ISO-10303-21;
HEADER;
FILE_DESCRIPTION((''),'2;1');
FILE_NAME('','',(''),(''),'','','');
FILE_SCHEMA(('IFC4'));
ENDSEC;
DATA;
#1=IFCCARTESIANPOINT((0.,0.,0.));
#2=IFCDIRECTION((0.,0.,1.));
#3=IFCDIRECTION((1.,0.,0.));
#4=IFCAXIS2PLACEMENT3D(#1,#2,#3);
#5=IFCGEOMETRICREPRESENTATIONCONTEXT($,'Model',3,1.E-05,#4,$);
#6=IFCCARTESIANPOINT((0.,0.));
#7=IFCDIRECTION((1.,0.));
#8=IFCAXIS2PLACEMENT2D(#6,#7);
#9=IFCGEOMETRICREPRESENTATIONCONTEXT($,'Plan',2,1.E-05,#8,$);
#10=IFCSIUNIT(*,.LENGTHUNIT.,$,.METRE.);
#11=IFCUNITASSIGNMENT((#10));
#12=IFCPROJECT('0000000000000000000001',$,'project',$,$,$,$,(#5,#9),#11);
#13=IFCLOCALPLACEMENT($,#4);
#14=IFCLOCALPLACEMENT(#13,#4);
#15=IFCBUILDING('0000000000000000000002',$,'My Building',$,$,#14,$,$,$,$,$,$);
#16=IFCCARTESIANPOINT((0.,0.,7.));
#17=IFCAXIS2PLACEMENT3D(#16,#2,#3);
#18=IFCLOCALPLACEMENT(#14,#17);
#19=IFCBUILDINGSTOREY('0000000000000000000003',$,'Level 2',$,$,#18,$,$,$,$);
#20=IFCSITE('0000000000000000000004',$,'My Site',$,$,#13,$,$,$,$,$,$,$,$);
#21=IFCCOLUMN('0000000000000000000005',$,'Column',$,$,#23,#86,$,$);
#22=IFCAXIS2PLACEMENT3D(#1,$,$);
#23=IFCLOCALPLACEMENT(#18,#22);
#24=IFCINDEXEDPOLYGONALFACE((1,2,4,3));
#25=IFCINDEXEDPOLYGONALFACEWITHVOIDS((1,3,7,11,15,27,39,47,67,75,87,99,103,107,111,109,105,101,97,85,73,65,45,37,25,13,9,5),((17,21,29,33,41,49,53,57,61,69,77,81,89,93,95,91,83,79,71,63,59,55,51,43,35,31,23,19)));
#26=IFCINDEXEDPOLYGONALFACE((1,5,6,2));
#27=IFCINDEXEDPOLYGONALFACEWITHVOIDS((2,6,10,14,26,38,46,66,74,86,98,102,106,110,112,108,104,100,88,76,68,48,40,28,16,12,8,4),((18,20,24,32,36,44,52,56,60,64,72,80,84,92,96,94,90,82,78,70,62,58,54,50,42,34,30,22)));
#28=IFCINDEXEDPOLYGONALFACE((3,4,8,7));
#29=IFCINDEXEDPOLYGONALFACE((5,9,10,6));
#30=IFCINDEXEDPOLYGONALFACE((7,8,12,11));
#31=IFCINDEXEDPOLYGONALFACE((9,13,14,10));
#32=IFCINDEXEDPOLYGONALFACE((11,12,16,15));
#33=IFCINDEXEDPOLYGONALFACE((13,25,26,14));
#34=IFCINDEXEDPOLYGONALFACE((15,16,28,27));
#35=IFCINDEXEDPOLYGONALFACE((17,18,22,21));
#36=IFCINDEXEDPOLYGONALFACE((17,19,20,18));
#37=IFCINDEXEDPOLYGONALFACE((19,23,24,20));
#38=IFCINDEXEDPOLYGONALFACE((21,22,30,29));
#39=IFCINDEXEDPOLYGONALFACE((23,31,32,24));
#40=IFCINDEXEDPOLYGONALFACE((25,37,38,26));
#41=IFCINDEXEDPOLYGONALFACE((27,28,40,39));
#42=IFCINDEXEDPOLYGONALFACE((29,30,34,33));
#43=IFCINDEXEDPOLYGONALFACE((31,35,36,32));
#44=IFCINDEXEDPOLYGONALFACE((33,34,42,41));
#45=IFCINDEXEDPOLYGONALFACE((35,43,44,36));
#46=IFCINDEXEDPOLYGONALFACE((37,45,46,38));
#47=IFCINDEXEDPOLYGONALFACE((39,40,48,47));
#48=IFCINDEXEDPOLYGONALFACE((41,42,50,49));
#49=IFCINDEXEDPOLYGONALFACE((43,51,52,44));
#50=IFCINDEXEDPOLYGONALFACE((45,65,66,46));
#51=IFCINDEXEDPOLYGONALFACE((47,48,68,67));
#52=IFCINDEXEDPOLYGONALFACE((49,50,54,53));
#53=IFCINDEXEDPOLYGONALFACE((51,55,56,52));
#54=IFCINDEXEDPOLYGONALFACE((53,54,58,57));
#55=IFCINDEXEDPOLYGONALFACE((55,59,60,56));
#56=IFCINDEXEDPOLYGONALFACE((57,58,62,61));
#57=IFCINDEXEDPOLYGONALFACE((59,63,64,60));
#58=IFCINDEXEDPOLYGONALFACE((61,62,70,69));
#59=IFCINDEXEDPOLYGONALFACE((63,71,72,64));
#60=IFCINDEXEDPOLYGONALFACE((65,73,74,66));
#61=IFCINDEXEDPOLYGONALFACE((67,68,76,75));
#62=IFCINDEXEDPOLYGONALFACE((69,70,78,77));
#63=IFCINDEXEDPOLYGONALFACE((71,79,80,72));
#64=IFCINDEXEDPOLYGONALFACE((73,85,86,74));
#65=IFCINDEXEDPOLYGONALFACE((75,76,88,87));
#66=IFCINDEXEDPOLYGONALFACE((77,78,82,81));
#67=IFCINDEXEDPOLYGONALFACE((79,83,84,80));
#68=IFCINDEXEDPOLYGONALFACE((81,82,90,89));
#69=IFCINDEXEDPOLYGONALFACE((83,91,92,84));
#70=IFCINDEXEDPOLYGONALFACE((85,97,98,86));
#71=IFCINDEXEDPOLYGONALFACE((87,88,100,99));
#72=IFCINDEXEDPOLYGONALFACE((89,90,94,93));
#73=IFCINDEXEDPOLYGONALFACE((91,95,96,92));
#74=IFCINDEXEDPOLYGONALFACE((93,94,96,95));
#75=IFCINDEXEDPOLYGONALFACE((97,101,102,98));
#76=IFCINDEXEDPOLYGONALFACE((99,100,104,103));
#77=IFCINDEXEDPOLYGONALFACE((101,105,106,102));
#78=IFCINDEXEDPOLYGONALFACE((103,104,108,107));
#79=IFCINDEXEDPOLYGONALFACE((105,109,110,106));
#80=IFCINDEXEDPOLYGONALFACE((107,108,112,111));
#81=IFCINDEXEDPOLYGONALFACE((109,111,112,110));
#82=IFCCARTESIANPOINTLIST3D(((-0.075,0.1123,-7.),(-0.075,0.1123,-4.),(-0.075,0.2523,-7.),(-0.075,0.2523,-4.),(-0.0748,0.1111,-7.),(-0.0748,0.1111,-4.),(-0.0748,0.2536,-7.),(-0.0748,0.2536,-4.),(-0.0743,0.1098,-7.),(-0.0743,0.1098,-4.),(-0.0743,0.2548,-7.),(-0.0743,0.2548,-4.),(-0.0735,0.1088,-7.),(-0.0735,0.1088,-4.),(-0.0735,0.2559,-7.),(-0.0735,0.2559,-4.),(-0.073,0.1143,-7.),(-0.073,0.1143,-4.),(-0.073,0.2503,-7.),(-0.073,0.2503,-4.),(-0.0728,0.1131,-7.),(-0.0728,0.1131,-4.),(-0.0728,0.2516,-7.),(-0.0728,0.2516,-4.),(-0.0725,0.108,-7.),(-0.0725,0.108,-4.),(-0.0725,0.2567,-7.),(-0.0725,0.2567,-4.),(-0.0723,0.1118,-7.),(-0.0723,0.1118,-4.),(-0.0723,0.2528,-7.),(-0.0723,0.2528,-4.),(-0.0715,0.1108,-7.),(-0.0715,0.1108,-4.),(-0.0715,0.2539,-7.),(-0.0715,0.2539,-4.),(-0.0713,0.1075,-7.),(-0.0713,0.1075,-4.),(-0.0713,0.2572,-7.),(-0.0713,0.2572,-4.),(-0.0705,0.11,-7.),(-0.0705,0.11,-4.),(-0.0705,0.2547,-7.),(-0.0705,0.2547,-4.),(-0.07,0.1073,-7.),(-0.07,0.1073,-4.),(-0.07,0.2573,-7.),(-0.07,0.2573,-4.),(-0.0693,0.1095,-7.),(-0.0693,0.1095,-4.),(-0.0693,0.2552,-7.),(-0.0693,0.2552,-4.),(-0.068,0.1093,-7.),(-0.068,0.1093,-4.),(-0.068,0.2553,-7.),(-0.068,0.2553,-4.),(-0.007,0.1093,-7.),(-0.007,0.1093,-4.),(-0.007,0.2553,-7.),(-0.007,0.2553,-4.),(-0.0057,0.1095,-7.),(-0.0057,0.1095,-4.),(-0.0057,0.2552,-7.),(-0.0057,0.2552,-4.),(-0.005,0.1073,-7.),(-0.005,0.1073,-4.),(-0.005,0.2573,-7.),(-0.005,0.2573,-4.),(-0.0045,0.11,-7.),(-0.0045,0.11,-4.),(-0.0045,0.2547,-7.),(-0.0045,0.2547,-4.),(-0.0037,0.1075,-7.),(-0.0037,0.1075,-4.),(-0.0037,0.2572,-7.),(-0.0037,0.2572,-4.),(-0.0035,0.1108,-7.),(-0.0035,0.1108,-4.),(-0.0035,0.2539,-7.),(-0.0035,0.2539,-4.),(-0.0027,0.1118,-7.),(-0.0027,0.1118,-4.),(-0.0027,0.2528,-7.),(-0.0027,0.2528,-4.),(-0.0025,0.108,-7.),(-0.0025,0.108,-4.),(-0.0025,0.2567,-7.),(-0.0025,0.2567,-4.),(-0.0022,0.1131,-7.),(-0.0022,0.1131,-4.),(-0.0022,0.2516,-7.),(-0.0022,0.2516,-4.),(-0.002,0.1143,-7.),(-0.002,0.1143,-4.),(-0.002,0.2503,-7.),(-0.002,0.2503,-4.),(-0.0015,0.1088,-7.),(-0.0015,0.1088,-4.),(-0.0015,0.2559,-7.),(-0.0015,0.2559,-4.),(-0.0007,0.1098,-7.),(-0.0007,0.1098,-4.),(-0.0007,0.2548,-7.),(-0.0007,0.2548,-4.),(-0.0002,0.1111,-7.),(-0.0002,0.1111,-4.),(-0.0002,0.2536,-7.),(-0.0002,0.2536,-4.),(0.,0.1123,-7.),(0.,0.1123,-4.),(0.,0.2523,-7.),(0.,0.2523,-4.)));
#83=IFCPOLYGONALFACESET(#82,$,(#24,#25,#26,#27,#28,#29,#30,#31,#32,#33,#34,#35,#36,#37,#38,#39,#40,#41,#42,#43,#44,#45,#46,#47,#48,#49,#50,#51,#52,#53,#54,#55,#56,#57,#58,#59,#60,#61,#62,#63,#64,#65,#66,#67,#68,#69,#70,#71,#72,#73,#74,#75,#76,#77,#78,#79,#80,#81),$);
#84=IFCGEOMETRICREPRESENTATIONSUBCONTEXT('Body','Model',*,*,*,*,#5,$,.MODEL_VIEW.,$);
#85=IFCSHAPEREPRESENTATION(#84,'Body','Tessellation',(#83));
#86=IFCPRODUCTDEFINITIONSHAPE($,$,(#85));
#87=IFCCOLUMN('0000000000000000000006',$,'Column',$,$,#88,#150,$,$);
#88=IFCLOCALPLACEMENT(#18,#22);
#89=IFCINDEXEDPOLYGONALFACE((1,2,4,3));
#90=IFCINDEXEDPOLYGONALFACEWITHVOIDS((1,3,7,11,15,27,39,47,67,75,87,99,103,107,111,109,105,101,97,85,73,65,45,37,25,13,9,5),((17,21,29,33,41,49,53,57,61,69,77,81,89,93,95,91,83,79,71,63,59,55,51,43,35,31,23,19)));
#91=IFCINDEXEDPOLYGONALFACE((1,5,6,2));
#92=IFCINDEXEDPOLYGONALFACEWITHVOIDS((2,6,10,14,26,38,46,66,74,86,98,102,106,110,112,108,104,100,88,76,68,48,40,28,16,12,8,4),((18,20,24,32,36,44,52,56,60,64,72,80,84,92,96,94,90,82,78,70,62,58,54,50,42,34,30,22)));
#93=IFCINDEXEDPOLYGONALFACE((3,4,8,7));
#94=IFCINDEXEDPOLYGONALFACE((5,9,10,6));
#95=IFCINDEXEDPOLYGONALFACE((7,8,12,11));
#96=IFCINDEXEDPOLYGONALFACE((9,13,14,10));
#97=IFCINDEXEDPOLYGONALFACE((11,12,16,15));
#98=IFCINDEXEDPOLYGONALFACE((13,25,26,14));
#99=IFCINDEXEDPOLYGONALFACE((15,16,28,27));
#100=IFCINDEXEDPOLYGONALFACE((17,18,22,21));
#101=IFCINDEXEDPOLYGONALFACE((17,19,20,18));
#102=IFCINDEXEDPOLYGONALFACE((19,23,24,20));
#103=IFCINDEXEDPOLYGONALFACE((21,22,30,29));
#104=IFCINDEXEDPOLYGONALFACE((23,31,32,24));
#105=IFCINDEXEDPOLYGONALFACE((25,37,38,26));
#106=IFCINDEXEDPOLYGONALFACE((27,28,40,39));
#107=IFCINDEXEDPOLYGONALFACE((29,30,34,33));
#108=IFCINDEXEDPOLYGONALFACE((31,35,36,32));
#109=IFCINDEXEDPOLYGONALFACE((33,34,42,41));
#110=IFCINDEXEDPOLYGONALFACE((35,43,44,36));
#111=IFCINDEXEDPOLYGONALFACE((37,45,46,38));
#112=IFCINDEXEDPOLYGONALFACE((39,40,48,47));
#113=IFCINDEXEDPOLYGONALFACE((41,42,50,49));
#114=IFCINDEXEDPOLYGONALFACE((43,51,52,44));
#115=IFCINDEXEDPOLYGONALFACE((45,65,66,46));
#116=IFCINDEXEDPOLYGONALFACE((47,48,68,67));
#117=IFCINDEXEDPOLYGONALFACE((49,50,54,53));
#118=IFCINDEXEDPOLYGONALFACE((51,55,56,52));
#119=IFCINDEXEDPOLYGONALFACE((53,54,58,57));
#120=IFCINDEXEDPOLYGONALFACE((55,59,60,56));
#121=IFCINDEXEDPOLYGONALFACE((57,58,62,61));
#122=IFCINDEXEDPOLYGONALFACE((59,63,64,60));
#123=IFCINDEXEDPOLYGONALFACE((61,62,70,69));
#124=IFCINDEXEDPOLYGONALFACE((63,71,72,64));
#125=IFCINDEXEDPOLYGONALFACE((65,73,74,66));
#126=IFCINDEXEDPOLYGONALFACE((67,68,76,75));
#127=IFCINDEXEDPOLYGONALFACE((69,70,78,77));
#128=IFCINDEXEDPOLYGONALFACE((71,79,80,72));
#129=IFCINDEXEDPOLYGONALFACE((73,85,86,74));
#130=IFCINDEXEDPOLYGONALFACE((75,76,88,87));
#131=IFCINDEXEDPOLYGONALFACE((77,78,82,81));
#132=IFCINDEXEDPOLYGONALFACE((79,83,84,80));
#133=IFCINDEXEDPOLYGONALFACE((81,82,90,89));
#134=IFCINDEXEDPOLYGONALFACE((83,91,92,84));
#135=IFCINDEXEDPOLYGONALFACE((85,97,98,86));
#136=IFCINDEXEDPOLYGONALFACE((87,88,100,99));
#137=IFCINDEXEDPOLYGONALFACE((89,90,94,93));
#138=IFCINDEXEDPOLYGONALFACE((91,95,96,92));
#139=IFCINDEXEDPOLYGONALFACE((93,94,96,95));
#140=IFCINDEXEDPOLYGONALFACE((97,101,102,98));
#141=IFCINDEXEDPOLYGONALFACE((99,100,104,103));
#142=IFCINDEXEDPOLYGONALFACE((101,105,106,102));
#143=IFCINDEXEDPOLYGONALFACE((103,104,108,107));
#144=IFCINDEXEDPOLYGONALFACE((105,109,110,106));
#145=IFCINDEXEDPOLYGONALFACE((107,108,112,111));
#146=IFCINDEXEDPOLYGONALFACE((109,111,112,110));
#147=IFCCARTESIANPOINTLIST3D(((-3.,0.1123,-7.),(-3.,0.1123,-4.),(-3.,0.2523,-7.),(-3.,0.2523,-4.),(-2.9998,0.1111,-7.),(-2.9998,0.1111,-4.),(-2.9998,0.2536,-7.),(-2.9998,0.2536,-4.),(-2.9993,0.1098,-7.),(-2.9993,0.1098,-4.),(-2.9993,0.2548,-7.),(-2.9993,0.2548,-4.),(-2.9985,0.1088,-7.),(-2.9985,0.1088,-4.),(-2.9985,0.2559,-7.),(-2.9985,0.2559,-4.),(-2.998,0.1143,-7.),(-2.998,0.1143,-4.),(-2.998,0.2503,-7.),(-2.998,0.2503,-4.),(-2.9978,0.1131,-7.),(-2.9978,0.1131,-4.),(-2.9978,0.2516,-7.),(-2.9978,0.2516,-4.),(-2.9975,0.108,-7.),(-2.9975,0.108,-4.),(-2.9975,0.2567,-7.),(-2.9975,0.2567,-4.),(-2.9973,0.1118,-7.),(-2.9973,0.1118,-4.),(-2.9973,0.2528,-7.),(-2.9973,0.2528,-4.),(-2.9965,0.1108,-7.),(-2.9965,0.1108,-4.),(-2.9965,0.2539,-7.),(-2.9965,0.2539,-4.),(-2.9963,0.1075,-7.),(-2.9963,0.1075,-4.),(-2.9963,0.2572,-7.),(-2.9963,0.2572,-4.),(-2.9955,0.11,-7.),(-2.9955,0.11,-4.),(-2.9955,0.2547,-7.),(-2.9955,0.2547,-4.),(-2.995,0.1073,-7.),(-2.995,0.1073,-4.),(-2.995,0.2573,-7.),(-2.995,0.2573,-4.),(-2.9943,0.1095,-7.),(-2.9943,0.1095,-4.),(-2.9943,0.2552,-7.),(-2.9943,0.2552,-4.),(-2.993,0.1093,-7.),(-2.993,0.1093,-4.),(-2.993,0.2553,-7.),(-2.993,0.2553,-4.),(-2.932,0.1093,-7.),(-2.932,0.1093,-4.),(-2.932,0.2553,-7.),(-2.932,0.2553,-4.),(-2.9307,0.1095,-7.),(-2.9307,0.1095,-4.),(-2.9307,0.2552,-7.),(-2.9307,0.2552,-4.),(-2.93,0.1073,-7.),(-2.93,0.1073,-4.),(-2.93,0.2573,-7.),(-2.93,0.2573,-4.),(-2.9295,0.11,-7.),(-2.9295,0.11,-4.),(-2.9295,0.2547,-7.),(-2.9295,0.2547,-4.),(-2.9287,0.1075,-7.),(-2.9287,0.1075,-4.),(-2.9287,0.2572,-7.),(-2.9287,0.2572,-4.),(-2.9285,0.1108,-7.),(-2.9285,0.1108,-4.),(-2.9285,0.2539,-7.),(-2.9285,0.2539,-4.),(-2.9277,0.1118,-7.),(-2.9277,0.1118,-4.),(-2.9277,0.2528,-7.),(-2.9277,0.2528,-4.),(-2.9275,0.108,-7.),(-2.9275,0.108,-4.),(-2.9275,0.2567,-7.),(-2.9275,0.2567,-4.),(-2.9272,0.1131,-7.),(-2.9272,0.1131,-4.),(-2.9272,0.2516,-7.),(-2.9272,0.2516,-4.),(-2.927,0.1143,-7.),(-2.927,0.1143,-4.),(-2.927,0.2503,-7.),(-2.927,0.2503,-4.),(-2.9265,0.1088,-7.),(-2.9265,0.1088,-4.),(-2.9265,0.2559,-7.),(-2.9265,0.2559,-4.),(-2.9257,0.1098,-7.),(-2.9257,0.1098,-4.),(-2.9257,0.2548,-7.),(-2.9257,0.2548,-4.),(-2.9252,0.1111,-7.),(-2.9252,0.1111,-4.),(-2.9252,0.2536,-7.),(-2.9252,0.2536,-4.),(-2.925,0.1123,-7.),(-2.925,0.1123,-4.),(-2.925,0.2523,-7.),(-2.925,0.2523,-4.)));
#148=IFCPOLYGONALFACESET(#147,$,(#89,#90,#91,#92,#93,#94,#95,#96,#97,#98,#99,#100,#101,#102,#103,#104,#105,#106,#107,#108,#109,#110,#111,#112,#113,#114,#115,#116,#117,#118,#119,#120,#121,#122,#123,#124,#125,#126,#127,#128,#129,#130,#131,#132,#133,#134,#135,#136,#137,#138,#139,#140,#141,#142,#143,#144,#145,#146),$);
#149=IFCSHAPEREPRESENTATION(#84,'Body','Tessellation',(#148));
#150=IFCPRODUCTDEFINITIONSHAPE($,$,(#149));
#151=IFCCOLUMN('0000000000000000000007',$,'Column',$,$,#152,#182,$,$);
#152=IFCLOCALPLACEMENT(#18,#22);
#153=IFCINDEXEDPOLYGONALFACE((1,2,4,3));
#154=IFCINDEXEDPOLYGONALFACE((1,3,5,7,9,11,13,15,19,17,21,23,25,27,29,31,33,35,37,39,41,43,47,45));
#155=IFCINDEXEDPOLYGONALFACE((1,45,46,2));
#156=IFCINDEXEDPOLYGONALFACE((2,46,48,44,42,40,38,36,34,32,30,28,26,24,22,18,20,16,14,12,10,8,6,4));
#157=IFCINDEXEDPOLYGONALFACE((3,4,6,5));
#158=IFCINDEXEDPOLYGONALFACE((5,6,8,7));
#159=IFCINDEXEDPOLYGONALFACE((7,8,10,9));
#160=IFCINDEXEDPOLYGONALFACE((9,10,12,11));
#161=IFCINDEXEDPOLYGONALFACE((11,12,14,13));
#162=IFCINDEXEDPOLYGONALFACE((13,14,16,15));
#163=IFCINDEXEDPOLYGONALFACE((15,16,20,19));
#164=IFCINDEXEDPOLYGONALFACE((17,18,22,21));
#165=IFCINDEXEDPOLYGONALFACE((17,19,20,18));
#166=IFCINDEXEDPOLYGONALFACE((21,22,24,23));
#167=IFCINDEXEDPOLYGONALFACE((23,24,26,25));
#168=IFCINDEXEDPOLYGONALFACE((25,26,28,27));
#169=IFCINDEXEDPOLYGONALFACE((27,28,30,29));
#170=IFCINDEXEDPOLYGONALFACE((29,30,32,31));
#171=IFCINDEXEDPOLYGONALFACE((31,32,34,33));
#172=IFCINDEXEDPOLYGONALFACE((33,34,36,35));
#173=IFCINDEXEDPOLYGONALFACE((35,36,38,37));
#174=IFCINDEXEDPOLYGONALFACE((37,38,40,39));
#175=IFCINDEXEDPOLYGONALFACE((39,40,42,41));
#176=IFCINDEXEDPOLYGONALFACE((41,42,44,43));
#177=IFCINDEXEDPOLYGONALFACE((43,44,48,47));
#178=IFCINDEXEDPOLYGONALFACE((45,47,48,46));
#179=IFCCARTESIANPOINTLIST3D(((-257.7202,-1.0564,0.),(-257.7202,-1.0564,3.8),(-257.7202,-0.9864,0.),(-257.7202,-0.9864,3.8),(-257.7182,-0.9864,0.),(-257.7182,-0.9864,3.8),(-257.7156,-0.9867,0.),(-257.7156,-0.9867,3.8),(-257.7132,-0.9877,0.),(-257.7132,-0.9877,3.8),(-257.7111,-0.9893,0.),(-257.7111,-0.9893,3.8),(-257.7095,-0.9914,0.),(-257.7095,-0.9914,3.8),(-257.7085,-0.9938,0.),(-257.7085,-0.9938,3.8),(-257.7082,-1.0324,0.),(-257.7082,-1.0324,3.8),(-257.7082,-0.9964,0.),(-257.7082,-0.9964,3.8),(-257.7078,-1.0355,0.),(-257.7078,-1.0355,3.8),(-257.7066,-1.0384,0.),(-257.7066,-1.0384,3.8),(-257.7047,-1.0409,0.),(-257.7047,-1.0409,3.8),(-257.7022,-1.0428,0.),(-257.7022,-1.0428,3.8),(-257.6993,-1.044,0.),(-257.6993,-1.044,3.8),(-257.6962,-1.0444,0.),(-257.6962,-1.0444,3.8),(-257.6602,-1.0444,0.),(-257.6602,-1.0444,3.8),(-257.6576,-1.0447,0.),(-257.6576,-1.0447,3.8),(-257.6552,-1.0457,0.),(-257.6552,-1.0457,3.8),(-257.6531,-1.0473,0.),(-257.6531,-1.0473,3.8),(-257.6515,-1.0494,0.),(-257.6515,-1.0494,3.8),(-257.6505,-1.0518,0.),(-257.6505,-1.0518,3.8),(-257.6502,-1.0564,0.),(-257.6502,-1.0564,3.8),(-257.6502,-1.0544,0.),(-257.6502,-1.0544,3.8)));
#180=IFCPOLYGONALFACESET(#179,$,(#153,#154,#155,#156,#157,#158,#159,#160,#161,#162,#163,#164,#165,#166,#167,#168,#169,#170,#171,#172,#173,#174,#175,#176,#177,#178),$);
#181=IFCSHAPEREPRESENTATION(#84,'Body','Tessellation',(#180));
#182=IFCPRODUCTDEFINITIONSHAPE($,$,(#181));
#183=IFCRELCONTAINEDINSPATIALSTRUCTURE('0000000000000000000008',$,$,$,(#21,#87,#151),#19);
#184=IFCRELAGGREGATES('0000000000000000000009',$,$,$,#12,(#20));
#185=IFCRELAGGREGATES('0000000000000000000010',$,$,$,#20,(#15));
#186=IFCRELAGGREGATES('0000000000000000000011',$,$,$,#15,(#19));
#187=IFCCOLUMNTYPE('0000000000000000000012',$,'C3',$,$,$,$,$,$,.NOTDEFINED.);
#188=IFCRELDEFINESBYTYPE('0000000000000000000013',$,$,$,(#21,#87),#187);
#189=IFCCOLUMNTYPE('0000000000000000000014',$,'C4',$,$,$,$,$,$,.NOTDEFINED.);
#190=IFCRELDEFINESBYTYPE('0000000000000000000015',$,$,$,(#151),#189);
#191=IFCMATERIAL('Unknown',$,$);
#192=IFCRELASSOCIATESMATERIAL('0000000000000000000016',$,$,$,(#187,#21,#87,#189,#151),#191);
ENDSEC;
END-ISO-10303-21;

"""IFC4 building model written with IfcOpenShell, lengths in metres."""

from ifc_helpers import new_model, si_unit, frame, origin_with_axes, origin_2d_with_axis, place, context, subcontext, project, spatial, hollow_rectangle, l_section, extrude, material, material_profile, profile_set, profile_usage, type_object, element, save


model = new_model("IFC4")

# Units and contexts
model_context = context("Model", 3, precision=1e-05, world=origin_with_axes())
plan_context = context("Plan", 2, precision=1e-05, world=origin_2d_with_axis())
body_context = subcontext(model_context, "Body", "Model", "MODEL_VIEW")
ifc_project = project(units=[si_unit("LENGTHUNIT", "METRE")], contexts=[model_context, plan_context])

# Site, building, storey
site_placement = place(None, origin_with_axes())
site = spatial("IfcSite", under=ifc_project, at=site_placement, Name="My Site")
building_placement = place(site_placement, origin_with_axes())
building = spatial("IfcBuilding", under=site, at=building_placement, Name="My Building")
storey_placement = place(building_placement, frame((0.0, 0.0, 7.0), z_axis=(0.0, 0.0, 1.0), x_axis=(1.0, 0.0, 0.0)))
storey = spatial("IfcBuildingStorey", under=building, at=storey_placement, Name="Level 2")

# Columns
ifc_material = material(Name="Unknown")
ifc_material_profile_1 = material_profile(ifc_material, hollow_rectangle(XDim=0.075, YDim=0.15, WallThickness=0.002, InnerFilletRadius=0.005, OuterFilletRadius=0.005))
ifc_profile_set_1 = profile_set([ifc_material_profile_1])
ifc_profile_usage_1 = profile_usage(ifc_profile_set_1, cardinal=5)
column_type_1 = type_object("IfcColumnType", Name="C3", PredefinedType="NOTDEFINED", material=ifc_profile_set_1)
column_1_placement = place(storey_placement, frame((-0.0375, 0.1823, -7.0), z_axis=(0.0, 0.0, 1.0), x_axis=(1.0, 0.0, 0.0)))
element("IfcColumn", 1, at=column_1_placement, inside=storey, type_object=column_type_1, material=ifc_profile_usage_1, Name="Column", context=body_context, shape_type="SweptSolid", body=[
    extrude(hollow_rectangle(XDim=0.075, YDim=0.15, WallThickness=0.002, InnerFilletRadius=0.005, OuterFilletRadius=0.005), origin_with_axes(), (0.0, 0.0, 1.0), 3.0),
])
ifc_profile_usage_2 = profile_usage(ifc_profile_set_1, cardinal=5)
column_2_placement = place(storey_placement, frame((-2.9625, 0.1823, -7.0), z_axis=(0.0, 0.0, 1.0), x_axis=(1.0, 0.0, 0.0)))
element("IfcColumn", 2, at=column_2_placement, inside=storey, type_object=column_type_1, material=ifc_profile_usage_2, Name="Column", context=body_context, shape_type="SweptSolid", body=[
    extrude(hollow_rectangle(XDim=0.075, YDim=0.15, WallThickness=0.002, InnerFilletRadius=0.005, OuterFilletRadius=0.005), origin_with_axes(), (0.0, 0.0, 1.0), 3.0),
])
ifc_material_profile_2 = material_profile(ifc_material, l_section(Depth=0.07, Width=0.07, Thickness=0.012, FilletRadius=0.012, EdgeRadius=0.01))
ifc_profile_set_2 = profile_set([ifc_material_profile_2], Name="C4")
ifc_profile_usage_3 = profile_usage(ifc_profile_set_2, cardinal=5)
column_type_2 = type_object("IfcColumnType", Name="C4", PredefinedType="NOTDEFINED", material=ifc_profile_set_2)
column_3_placement = place(storey_placement, frame((-257.6852, -1.0214, 0.0), z_axis=(0.0, 0.0, 1.0), x_axis=(1.0, 0.0, 0.0)))
element("IfcColumn", 3, at=column_3_placement, inside=storey, type_object=column_type_2, material=ifc_profile_usage_3, Name="Column", context=body_context, shape_type="SweptSolid", body=[
    extrude(l_section(Depth=0.07, Width=0.07, Thickness=0.012, FilletRadius=0.012, EdgeRadius=0.01), origin_with_axes(), (0.0, 0.0, 1.0), 3.8),
])

save(model, "model.ifc")
